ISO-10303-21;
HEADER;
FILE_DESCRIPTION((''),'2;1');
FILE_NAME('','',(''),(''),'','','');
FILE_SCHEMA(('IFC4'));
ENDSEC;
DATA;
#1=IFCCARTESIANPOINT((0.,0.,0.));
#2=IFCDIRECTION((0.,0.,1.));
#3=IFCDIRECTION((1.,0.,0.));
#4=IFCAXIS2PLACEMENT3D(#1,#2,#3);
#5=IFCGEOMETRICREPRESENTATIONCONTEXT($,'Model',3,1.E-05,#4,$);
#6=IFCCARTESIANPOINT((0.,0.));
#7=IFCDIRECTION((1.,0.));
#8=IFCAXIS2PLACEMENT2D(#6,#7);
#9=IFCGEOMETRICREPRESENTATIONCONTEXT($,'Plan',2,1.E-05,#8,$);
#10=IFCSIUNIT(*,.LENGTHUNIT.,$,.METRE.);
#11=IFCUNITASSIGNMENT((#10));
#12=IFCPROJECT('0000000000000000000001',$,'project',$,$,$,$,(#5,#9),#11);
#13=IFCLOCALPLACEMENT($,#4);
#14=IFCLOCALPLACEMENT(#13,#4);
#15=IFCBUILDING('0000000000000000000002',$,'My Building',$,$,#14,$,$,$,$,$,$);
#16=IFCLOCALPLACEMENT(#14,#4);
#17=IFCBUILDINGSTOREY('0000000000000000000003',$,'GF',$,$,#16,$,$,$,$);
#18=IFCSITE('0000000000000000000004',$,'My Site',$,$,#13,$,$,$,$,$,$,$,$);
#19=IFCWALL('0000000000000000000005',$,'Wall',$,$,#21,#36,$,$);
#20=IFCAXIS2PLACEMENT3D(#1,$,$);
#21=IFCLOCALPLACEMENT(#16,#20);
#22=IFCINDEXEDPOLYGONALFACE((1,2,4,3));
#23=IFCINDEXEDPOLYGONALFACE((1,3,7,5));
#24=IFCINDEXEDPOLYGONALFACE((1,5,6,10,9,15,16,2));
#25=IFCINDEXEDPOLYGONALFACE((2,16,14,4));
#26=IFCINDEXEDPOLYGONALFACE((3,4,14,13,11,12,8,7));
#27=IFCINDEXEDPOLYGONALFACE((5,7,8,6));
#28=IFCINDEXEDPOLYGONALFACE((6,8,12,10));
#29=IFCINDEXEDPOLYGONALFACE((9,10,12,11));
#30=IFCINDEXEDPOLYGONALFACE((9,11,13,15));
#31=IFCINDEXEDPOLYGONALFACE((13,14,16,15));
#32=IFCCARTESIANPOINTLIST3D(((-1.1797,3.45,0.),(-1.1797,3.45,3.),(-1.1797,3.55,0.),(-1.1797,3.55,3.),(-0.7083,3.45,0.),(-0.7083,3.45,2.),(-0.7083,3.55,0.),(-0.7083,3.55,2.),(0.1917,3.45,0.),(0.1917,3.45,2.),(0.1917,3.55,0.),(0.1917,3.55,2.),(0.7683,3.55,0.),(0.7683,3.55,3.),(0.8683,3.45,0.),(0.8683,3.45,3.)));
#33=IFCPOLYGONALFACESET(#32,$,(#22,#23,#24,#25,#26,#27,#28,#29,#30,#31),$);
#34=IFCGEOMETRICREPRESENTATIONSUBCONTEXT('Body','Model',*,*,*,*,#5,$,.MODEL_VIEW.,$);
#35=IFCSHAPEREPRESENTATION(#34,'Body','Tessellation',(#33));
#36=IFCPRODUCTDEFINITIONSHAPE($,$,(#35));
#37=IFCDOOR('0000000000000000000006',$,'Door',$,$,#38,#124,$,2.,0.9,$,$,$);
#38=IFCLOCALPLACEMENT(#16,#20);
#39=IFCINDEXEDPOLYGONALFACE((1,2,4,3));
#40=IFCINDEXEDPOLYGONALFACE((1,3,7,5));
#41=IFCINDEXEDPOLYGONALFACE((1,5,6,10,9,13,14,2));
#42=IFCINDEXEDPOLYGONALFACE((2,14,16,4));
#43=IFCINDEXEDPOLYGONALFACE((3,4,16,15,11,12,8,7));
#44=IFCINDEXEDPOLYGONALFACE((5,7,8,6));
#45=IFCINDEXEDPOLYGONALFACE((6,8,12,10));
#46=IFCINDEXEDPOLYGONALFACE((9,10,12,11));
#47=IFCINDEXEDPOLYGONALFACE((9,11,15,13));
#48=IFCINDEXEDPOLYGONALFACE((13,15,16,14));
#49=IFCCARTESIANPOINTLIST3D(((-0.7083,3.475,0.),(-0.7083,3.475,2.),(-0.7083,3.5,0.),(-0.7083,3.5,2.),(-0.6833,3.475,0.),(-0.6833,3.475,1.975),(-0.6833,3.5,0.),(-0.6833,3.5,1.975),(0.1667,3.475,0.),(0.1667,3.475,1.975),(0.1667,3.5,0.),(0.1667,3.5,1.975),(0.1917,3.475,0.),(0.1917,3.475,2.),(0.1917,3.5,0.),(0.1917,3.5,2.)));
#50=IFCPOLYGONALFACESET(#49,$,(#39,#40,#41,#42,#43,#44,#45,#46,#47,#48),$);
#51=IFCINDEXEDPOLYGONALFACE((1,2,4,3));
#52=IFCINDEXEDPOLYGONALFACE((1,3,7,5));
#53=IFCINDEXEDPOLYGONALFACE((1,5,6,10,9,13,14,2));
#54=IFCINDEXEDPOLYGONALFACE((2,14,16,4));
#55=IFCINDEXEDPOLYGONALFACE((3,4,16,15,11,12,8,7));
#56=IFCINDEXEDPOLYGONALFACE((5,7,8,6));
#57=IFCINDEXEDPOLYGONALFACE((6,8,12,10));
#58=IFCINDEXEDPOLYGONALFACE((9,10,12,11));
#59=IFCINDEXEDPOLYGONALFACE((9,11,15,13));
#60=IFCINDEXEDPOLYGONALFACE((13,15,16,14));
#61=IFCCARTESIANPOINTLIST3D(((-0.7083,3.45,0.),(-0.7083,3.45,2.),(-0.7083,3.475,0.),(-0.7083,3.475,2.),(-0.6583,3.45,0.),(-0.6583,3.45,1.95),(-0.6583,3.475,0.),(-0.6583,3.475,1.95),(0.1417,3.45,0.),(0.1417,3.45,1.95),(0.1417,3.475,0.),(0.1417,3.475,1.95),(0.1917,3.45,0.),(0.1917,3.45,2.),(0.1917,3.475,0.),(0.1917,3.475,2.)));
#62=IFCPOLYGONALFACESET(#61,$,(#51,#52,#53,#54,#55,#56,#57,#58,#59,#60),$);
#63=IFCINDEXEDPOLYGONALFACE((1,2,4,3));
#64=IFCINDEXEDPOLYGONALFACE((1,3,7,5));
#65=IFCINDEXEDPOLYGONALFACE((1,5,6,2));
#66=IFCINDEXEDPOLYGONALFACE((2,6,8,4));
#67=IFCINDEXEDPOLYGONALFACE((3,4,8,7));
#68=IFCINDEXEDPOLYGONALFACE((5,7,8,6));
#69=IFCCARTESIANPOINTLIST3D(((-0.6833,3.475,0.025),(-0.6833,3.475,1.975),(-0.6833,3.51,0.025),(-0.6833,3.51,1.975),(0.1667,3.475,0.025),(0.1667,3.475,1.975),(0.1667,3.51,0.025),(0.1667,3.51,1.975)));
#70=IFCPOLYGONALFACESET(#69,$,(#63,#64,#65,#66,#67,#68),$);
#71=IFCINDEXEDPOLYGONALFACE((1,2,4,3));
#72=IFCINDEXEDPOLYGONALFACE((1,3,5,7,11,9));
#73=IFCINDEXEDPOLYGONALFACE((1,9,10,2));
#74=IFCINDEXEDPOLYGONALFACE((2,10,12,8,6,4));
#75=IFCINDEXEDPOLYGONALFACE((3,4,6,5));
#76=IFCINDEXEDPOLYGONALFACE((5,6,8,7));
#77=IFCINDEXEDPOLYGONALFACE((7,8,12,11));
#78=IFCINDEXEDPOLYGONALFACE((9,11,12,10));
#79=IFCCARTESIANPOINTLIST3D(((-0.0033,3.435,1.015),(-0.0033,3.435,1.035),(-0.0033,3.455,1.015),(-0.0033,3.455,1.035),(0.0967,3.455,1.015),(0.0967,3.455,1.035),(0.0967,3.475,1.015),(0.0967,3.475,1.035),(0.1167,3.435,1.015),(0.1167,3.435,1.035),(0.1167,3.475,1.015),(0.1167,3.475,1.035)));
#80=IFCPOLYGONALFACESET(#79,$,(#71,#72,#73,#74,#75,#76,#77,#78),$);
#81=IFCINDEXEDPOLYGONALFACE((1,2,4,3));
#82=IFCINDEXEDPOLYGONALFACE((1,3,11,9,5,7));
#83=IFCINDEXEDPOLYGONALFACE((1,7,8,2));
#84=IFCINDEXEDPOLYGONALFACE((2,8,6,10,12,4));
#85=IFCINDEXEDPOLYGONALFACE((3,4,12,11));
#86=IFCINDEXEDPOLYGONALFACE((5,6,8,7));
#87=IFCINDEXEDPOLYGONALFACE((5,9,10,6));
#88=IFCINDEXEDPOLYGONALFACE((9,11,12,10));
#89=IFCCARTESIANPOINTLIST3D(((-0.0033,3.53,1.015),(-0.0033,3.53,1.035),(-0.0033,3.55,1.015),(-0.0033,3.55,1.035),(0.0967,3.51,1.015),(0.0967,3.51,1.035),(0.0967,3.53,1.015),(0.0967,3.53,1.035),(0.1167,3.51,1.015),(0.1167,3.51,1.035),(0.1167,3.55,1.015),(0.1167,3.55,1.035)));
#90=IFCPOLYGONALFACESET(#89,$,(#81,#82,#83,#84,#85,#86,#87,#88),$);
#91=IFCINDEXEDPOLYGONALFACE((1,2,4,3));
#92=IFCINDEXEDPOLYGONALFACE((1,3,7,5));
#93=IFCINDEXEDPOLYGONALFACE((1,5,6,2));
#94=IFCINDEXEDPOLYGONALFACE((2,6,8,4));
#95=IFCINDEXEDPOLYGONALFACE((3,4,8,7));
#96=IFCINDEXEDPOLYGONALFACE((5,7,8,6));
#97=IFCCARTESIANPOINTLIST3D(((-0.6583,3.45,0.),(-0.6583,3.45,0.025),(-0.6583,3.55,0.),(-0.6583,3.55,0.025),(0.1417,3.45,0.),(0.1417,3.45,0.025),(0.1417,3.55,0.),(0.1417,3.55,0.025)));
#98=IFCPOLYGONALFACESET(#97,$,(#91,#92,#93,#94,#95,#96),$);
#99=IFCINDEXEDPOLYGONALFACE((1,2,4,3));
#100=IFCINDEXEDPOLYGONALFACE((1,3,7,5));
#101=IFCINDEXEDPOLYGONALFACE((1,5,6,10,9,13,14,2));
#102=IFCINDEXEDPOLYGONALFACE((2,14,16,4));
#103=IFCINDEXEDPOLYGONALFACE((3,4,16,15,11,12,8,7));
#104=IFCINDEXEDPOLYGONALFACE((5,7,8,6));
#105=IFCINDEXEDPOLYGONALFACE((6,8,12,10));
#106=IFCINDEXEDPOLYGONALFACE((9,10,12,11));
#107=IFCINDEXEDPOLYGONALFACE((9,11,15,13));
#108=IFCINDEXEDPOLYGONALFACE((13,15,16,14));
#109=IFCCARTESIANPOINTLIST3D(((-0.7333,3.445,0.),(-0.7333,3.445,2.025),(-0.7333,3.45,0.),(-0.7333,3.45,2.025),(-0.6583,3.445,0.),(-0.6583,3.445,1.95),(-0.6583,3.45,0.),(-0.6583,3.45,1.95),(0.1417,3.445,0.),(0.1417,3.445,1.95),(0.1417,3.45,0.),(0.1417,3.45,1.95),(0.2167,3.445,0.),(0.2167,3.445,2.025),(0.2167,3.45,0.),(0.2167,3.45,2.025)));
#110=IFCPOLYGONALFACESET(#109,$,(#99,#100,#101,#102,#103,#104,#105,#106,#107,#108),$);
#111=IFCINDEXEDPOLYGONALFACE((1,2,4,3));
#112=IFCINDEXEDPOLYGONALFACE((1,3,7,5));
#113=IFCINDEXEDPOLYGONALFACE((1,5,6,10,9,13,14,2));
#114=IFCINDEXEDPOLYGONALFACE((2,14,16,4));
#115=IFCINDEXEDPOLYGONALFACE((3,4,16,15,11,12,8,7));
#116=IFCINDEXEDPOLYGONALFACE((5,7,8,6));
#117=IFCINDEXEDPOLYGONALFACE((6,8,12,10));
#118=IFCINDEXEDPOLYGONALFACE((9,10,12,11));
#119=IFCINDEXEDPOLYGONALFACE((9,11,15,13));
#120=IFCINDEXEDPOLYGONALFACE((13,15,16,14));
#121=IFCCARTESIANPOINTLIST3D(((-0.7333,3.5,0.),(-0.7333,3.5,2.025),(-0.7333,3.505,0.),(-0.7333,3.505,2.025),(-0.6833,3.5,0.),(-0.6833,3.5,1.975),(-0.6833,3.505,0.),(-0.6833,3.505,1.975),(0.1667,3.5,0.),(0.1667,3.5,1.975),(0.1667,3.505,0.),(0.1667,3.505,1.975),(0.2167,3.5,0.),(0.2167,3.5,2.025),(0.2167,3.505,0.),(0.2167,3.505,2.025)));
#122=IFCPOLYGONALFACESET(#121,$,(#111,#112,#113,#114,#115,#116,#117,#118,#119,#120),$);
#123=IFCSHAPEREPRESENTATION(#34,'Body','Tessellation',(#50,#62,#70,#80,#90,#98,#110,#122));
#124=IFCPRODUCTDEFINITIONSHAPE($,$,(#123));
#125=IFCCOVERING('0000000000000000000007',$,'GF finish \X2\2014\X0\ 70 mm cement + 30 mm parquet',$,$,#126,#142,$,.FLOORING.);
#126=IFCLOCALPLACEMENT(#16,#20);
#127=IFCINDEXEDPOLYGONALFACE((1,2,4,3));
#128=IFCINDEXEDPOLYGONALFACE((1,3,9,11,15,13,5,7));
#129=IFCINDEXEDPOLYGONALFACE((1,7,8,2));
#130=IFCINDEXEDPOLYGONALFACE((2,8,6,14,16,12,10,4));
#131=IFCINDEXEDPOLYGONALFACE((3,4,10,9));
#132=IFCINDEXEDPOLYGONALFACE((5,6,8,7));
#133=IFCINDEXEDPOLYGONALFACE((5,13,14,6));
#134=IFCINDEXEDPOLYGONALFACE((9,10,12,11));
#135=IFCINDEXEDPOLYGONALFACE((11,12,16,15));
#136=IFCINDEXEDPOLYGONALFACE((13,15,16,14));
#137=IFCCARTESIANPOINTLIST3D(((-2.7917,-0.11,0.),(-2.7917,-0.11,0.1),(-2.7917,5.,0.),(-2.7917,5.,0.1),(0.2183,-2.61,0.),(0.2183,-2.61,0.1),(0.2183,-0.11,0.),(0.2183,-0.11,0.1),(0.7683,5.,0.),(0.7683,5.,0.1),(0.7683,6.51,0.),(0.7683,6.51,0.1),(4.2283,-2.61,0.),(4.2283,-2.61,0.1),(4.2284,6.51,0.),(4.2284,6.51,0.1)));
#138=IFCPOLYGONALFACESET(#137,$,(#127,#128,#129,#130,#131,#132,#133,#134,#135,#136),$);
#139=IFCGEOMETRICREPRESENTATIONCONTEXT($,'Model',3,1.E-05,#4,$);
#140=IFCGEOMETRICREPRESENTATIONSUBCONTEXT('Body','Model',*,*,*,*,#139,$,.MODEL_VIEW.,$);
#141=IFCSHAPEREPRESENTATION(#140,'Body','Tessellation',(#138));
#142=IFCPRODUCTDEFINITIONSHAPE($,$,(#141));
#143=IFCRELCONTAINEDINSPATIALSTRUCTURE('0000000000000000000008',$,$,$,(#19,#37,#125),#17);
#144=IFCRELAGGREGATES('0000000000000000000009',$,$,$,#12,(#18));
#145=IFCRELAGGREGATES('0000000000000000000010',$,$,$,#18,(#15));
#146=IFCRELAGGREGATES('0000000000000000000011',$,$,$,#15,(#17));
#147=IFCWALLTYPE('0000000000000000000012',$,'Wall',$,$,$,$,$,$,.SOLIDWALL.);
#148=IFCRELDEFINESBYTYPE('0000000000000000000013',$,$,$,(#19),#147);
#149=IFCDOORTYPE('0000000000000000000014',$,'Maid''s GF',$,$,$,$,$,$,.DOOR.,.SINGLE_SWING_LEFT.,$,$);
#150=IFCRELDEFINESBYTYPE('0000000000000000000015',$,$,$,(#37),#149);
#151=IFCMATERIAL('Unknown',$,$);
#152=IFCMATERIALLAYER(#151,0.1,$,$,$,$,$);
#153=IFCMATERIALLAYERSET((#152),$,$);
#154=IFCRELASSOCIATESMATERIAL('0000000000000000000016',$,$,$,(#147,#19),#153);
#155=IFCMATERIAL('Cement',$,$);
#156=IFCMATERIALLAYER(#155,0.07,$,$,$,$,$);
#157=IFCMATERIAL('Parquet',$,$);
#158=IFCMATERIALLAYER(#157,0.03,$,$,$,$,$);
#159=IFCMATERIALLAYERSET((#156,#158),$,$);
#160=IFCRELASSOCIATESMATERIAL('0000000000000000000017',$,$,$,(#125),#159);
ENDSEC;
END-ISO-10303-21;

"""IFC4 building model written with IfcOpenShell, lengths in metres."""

from ifc_helpers import new_model, entity, si_unit, frame, origin_with_axes, origin_2d_with_axis, place, context, subcontext, project, spatial, line, indexed_curve, outline, extrude, shape, source, transform, mapped, material, layer, layer_set, layer_usage, type_object, type_shapes, element, fill, save


model = new_model("IFC4")

# Units and contexts
model_context_1 = context("Model", 3, precision=1e-05, world=origin_with_axes())
plan_context = context("Plan", 2, precision=1e-05, world=origin_2d_with_axis())
model_context_2 = context("Model", 3, precision=1e-05, world=origin_with_axes())
body_context_1 = subcontext(model_context_1, "Body", "Model", "MODEL_VIEW")
body_context_2 = subcontext(plan_context, "Body", "Plan", "PLAN_VIEW")
body_context_3 = subcontext(model_context_2, "Body", "Model", "MODEL_VIEW")
ifc_project = project(units=[si_unit("LENGTHUNIT", "METRE")], contexts=[model_context_1, plan_context])

# Site, building, storey
site_placement = place(None, origin_with_axes())
site = spatial("IfcSite", under=ifc_project, at=site_placement, Name="My Site")
building_placement = place(site_placement, origin_with_axes())
building = spatial("IfcBuilding", under=site, at=building_placement, Name="My Building")
storey_placement = place(building_placement, origin_with_axes())
storey = spatial("IfcBuildingStorey", under=building, at=storey_placement, Name="GF")

# Shared definitions
ifc_material_1 = material(Name="Unknown")

# Shared definitions
ifc_layer_1 = layer(ifc_material_1, 0.1)
ifc_layer_set_1 = layer_set([ifc_layer_1])
wall_type = type_object("IfcWallType", Name="Wall", PredefinedType="SOLIDWALL", material=ifc_layer_set_1)

# Wall, opening, door
ifc_layer_usage_1 = layer_usage(ifc_layer_set_1, "AXIS2", "POSITIVE", 0.0)
wall_1_placement = place(storey_placement, frame((0.7683, 3.55, 0.0), z_axis=(0.0, 0.0, 1.0), x_axis=(-1.0, 0.0, 0.0)))
wall_1 = element("IfcWall", 1, at=wall_1_placement, inside=storey, type_object=wall_type, material=ifc_layer_usage_1, Name="Wall", context=body_context_1, shape_type="SweptSolid", body=[
    extrude(outline(indexed_curve([(0.0, 0.0), (-0.1, 0.1), (1.948, 0.1), (1.948, 0.0)], segments=[line(1, 2, 3, 4, 1)])), origin_with_axes(), (0.0, 0.0, 1.0), 3.0),
])
shared_shape_1 = source(origin_with_axes(), body_context_1, "Body", "SweptSolid", [
    extrude(outline(indexed_curve([(0.0, 0.0), (0.9, 0.0), (0.9, 2.0), (0.0, 2.0)], segments=[line(1, 2, 3, 4, 1)])), frame((0.0, -0.6, 0.0), z_axis=(0.0, -1.0, 0.0), x_axis=(1.0, 0.0, 0.0)), (0.0, 0.0, -1.0), 1.2),
])
opening_1_placement = place(wall_1_placement, frame((1.4766, 0.1, 0.0), z_axis=(0.0, 0.0, 1.0), x_axis=(-1.0, 0.0, 0.0)))
opening_1 = element("IfcOpeningElement", 2, at=opening_1_placement, cuts=wall_1, PredefinedType="OPENING", context=body_context_1, shape_type="MappedRepresentation", body=[
    mapped(shared_shape_1, transform((0.0, 0.0, 0.0), x_axis=(1.0, 0.0, 0.0), y_axis=(0.0, 1.0, 0.0), z_axis=(0.0, 0.0, 1.0), scale=1.0)),
])
door_type_1 = type_object("IfcDoorType", Name="Maid's GF", OperationType="SINGLE_SWING_LEFT", PredefinedType="DOOR")
shared_shape_2 = source(origin_with_axes(), body_context_1, "Body", "SweptSolid", [
    extrude(outline(indexed_curve([(0.0, 0.0), (0.0, 2.0), (0.9, 2.0), (0.9, 0.0), (0.875, 0.0), (0.875, 1.975), (0.025, 1.975), (0.025, 0.0)], segments=[line(1, 2, 3, 4, 5, 6, 7, 8, 1)])), frame((0.0, 0.025, 0.0), z_axis=(0.0, -1.0, 0.0), x_axis=(1.0, 0.0, 0.0)), (0.0, 0.0, -1.0), 0.025),
    extrude(outline(indexed_curve([(0.0, 0.0), (0.0, 2.0), (0.9, 2.0), (0.9, 0.0), (0.85, 0.0), (0.85, 1.95), (0.05, 1.95), (0.05, 0.0)], segments=[line(1, 2, 3, 4, 5, 6, 7, 8, 1)])), frame((0.0, 0.0, 0.0), z_axis=(0.0, -1.0, 0.0), x_axis=(1.0, 0.0, 0.0)), (0.0, 0.0, -1.0), 0.025),
    extrude(outline(indexed_curve([(0.0, 0.0), (0.85, 0.0), (0.85, 0.035), (0.0, 0.035)], segments=[line(1, 2, 3, 4, 1)])), frame((0.025, 0.025, 0.025), z_axis=(0.0, 0.0, 1.0), x_axis=(1.0, 0.0, 0.0)), (0.0, 0.0, 1.0), 1.95),
    extrude(outline(indexed_curve([(0.0, 0.0), (0.0, -0.04), (-0.12, -0.04), (-0.12, -0.02), (-0.02, -0.02), (-0.02, 0.0)], segments=[line(1, 2, 3, 4, 5, 6, 1)])), frame((0.825, 0.025, 1.015), z_axis=(0.0, 0.0, 1.0), x_axis=(1.0, 0.0, 0.0)), (0.0, 0.0, 1.0), 0.02),
    extrude(outline(indexed_curve([(0.0, 0.0), (0.0, 0.04), (-0.12, 0.04), (-0.12, 0.02), (-0.02, 0.02), (-0.02, 0.0)], segments=[line(1, 2, 3, 4, 5, 6, 1)])), frame((0.825, 0.06, 1.015), z_axis=(0.0, 0.0, 1.0), x_axis=(1.0, 0.0, 0.0)), (0.0, 0.0, 1.0), 0.02),
    extrude(outline(indexed_curve([(0.0, 0.0), (0.8, 0.0), (0.8, 0.1), (0.0, 0.1)], segments=[line(1, 2, 3, 4, 1)])), frame((0.05, 0.0, 0.0), z_axis=(0.0, 0.0, 1.0), x_axis=(1.0, 0.0, 0.0)), (0.0, 0.0, 1.0), 0.025),
    extrude(outline(indexed_curve([(0.0, 0.0), (0.0, 2.025), (0.95, 2.025), (0.95, 0.0), (0.875, 0.0), (0.875, 1.95), (0.075, 1.95), (0.075, 0.0)], segments=[line(1, 2, 3, 4, 5, 6, 7, 8, 1)])), frame((-0.025, -0.005, 0.0), z_axis=(0.0, -1.0, 0.0), x_axis=(1.0, 0.0, 0.0)), (0.0, 0.0, -1.0), 0.005),
    extrude(outline(indexed_curve([(0.0, 0.0), (0.0, 2.025), (0.95, 2.025), (0.95, 0.0), (0.9, 0.0), (0.9, 1.975), (0.05, 1.975), (0.05, 0.0)], segments=[line(1, 2, 3, 4, 5, 6, 7, 8, 1)])), frame((-0.025, 0.05, 0.0), z_axis=(0.0, -1.0, 0.0), x_axis=(1.0, 0.0, 0.0)), (0.0, 0.0, -1.0), 0.005),
])
shared_shape_3 = source(origin_with_axes(), body_context_2, "Body", "Curve2D", [
    entity("IfcIndexedPolyCurve", entity("IfcCartesianPointList2D", [[0.0, 0.0], [0.0, 0.05], [0.025, 0.05], [0.025, 0.025], [0.05, 0.025], [0.05, 0.0]]), [entity("IfcLineIndex", [1, 2, 3, 4, 5, 6, 1])]),
    entity("IfcIndexedPolyCurve", entity("IfcCartesianPointList2D", [[0.9, 0.0], [0.9, 0.05], [0.875, 0.05], [0.875, 0.025], [0.85, 0.025], [0.85, 0.0]]), [entity("IfcLineIndex", [1, 2, 3, 4, 5, 6, 1])]),
    entity("IfcTrimmedCurve", entity("IfcEllipse", entity("IfcAxis2Placement2D", entity("IfcCartesianPoint", [0.06, 0.05]), entity("IfcDirection", [1.0, 0.0])), 0.815, 0.85), [entity("IfcCartesianPoint", [0.875, 0.05])], [entity("IfcCartesianPoint", [0.06, 0.9])], True, "CARTESIAN"),
    entity("IfcIndexedPolyCurve", entity("IfcCartesianPointList2D", [[0.025, 0.05], [0.06, 0.05], [0.06, 0.9], [0.025, 0.9]]), [entity("IfcLineIndex", [1, 2, 3, 4, 1])]),
])
type_shapes(door_type_1, [shared_shape_2, shared_shape_3])
door_1_placement = place(opening_1_placement, frame((0.0, 0.0, 0.0), z_axis=(0.0, 0.0, 1.0), x_axis=(1.0, 0.0, 0.0)))
door_1 = element("IfcDoor", 3, at=door_1_placement, inside=storey, type_object=door_type_1, Name="Door", OverallHeight=2.0, OverallWidth=0.9, shapes=[
    shape(body_context_1, "Body", "MappedRepresentation", [mapped(shared_shape_2, transform((0.0, 0.0, 0.0), x_axis=(1.0, 0.0, 0.0), y_axis=(0.0, 1.0, 0.0), z_axis=(0.0, 0.0, 1.0), scale=1.0))]),
    shape(body_context_2, "Body", "MappedRepresentation", [mapped(shared_shape_3, transform((0.0, 0.0, 0.0), x_axis=(1.0, 0.0, 0.0), y_axis=(0.0, 1.0, 0.0), z_axis=(0.0, 0.0, 1.0), scale=1.0))]),
])
fill(opening_1, door_1)

# Covering
ifc_material_2 = material(Name="Cement")
ifc_layer_2 = layer(ifc_material_2, 0.07)
ifc_material_3 = material(Name="Parquet")
ifc_layer_3 = layer(ifc_material_3, 0.03)
ifc_layer_set_2 = layer_set([ifc_layer_2, ifc_layer_3])
placement_1 = place(None, origin_with_axes())
placement_2 = place(placement_1, origin_with_axes())
placement_3 = place(placement_2, origin_with_axes())
covering_placement = place(placement_3, frame((0.2183, -2.61, 0.0), z_axis=(0.0, 0.0, 1.0), x_axis=(1.0, 0.0, 0.0)))
element("IfcCovering", 4, at=covering_placement, inside=storey, material=ifc_layer_set_2, Name="GF finish — 70 mm cement + 30 mm parquet", PredefinedType="FLOORING", context=body_context_3, shape_type="SweptSolid", body=[
    extrude(outline(indexed_curve([(4.01, 0.0), (4.01, 9.12), (0.55, 9.12), (0.55, 7.61), (-3.01, 7.61), (-3.01, 2.5), (0.0, 2.5), (0.0, 0.0), (4.01, 0.0)])), origin_with_axes(), (0.0, 0.0, 1.0), 0.1),
])

save(model, "model.ifc")
